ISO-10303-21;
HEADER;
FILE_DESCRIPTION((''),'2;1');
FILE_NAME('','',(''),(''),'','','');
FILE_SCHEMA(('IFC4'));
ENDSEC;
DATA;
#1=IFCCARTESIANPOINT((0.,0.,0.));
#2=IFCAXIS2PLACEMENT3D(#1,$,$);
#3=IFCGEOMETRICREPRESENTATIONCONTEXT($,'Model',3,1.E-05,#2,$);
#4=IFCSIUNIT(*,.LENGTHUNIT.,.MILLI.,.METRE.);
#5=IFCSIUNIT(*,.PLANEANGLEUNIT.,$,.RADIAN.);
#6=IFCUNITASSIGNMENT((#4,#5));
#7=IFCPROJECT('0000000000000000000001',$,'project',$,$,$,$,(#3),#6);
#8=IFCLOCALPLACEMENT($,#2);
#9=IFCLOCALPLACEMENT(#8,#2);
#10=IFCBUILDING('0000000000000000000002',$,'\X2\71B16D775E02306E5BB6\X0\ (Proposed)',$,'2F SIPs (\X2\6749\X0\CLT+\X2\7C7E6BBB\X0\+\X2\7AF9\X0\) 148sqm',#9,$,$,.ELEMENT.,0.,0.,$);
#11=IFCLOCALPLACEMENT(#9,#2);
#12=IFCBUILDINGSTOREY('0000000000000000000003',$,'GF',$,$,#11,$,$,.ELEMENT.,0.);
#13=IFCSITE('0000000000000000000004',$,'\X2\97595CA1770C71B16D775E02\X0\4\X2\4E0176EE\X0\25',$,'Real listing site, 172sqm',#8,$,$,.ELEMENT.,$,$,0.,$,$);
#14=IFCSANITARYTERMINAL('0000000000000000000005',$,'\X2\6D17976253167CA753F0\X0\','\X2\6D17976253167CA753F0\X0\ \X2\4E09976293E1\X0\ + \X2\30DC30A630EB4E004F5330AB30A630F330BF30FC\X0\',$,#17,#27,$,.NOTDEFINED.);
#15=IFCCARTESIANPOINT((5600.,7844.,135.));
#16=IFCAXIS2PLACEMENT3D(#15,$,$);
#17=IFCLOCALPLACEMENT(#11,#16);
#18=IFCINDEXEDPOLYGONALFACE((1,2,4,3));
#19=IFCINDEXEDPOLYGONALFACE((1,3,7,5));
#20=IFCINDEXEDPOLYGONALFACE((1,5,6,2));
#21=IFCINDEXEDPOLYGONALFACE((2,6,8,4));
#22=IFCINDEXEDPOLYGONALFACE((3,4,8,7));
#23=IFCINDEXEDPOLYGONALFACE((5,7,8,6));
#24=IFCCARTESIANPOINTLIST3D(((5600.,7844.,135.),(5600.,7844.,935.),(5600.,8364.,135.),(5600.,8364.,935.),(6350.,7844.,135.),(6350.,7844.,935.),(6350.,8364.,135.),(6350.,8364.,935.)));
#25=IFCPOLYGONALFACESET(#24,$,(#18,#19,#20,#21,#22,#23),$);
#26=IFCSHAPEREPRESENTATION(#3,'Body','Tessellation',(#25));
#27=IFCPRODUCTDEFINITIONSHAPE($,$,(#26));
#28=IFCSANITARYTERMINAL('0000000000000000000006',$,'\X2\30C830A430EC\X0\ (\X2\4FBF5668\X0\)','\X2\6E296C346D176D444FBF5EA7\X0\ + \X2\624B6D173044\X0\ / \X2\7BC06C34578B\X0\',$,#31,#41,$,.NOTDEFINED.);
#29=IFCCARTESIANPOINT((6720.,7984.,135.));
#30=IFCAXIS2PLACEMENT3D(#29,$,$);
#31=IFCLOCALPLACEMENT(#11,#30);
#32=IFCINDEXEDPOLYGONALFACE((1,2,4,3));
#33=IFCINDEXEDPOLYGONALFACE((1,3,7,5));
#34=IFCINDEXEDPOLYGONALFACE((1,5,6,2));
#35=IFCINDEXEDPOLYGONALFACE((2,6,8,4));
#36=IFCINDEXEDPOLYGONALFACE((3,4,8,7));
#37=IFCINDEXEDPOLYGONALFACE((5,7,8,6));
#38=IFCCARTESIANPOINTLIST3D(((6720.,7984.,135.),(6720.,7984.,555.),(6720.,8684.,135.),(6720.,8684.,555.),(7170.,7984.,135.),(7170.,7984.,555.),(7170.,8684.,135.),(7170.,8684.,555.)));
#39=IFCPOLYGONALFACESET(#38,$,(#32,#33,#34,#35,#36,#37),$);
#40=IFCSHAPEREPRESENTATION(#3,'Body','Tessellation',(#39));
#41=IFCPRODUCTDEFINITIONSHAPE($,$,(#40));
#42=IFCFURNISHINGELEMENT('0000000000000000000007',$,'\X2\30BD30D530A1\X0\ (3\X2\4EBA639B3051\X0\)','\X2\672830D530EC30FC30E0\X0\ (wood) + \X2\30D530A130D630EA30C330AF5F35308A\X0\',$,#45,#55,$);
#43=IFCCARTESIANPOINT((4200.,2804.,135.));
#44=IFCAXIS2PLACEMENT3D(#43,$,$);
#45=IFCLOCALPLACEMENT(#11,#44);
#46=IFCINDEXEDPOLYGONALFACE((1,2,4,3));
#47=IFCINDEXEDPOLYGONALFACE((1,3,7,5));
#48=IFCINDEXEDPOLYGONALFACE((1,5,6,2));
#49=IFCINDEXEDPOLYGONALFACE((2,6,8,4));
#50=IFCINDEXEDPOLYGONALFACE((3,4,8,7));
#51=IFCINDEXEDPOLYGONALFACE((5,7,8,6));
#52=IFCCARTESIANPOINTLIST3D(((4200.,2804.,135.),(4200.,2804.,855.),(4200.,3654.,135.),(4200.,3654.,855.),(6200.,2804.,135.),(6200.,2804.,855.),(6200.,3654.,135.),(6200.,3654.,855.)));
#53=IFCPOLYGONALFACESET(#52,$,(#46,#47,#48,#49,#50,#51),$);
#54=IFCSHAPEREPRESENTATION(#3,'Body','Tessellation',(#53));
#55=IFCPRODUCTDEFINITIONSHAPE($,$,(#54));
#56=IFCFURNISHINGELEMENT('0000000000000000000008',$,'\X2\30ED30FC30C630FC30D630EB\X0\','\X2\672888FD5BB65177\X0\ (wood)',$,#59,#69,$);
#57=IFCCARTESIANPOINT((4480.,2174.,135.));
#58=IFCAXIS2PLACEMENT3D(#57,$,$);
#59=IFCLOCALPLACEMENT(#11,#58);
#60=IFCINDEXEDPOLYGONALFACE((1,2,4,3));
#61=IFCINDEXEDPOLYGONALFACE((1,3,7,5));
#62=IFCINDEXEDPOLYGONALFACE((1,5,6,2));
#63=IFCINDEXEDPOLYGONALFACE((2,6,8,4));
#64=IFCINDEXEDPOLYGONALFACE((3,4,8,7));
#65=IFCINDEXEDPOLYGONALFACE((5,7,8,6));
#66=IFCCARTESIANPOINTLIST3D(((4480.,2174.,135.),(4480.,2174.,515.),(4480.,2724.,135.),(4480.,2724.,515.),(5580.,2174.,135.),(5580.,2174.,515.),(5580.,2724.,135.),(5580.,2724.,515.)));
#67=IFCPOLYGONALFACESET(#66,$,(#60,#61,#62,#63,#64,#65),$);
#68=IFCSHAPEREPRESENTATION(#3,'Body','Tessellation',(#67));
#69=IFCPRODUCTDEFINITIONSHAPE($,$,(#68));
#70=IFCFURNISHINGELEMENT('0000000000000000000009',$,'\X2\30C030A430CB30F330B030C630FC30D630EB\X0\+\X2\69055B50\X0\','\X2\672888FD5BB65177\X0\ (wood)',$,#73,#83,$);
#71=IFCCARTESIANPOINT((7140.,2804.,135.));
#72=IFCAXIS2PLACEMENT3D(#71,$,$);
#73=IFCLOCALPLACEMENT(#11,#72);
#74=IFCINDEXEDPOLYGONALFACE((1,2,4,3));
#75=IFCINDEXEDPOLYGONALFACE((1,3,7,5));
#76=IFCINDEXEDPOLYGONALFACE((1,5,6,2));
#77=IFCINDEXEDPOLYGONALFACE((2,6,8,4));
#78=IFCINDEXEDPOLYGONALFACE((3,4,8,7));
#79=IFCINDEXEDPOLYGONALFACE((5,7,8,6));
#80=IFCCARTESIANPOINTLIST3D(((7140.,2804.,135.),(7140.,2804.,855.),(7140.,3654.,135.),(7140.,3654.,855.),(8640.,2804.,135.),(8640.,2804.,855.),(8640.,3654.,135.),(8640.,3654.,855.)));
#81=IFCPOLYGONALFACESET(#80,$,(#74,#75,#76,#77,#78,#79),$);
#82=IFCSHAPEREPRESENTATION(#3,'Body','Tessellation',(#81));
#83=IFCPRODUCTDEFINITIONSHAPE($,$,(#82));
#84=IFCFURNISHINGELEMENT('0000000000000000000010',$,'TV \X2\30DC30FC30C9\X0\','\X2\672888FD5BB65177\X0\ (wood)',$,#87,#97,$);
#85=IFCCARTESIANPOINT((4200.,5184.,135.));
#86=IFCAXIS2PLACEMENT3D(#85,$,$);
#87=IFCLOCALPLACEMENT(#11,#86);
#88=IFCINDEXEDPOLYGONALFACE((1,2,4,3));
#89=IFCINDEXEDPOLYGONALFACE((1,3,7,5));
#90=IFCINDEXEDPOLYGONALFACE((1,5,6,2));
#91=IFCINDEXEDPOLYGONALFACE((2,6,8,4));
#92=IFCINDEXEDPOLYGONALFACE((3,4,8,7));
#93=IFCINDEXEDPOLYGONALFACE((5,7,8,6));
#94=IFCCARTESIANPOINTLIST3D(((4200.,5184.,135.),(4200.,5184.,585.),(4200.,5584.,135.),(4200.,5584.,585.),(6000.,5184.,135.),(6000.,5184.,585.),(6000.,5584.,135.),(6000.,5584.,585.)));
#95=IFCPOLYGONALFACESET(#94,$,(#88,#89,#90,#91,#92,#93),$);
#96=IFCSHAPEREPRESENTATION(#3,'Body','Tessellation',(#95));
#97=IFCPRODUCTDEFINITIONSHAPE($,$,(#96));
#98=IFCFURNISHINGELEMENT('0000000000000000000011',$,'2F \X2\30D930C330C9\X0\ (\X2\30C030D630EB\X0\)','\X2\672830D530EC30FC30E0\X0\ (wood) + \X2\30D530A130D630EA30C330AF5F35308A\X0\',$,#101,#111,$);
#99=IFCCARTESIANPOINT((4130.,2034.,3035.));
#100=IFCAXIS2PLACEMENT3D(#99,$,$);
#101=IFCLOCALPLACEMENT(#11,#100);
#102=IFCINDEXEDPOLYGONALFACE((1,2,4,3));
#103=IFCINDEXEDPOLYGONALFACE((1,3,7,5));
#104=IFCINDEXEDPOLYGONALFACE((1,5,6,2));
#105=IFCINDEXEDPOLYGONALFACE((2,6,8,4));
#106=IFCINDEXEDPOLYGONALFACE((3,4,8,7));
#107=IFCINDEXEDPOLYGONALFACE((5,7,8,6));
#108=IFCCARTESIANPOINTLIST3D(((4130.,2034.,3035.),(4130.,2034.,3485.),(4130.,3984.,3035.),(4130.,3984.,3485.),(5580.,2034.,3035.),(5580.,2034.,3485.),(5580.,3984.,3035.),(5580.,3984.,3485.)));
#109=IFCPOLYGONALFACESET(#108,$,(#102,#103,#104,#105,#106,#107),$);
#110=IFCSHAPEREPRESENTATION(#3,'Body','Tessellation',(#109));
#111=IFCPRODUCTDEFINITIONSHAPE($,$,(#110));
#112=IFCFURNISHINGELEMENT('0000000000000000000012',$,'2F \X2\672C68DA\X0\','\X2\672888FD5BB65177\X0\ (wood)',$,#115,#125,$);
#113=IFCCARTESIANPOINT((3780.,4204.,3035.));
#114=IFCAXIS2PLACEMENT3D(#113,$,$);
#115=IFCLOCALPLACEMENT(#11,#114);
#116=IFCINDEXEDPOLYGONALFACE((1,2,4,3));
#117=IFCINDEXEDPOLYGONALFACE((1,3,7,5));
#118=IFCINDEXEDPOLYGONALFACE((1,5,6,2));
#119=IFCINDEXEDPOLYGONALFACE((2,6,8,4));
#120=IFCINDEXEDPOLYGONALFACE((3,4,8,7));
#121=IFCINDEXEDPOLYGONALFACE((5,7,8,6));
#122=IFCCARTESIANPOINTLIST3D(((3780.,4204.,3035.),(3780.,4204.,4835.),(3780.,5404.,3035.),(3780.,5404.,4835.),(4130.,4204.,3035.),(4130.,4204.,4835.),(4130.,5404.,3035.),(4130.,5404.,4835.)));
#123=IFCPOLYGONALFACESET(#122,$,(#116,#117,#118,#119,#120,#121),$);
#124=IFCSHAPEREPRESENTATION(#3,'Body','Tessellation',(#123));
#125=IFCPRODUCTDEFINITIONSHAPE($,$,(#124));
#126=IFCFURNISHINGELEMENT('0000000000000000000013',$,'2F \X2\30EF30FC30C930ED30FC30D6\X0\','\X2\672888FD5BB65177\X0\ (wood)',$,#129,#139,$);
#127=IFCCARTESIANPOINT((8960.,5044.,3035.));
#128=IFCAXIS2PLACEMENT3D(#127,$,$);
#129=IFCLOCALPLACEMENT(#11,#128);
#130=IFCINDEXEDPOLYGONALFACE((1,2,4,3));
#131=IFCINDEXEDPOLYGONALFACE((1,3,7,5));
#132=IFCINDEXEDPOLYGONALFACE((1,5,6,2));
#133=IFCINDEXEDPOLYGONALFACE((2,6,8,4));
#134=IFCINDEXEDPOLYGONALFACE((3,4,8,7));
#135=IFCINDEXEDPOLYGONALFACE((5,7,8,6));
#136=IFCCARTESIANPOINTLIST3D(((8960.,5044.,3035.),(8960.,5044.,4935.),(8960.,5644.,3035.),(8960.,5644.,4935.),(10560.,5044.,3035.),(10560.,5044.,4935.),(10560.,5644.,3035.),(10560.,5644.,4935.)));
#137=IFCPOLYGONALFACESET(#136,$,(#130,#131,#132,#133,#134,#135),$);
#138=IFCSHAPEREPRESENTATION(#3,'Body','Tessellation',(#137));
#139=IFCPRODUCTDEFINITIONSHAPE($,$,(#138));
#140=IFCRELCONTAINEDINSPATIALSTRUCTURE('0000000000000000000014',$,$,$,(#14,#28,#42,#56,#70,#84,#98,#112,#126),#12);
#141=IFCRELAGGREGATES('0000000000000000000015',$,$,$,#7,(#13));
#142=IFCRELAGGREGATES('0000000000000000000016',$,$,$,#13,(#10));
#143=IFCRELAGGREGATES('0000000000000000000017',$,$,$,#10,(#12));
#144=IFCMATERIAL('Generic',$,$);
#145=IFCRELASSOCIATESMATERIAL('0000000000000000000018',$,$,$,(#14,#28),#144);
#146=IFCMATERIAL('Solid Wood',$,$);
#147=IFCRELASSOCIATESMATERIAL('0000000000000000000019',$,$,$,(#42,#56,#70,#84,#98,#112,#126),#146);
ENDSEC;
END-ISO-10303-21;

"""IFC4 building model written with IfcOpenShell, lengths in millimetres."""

from ifc_helpers import new_model, si_unit, frame, frame_2d, origin, place, context, project, spatial, rectangle, extrude, material, element, save


model = new_model("IFC4")

# Units and contexts
model_context = context("Model", 3, precision=1e-05, world=origin())
ifc_project = project(units=[si_unit("LENGTHUNIT", "METRE", prefix="MILLI"), si_unit("PLANEANGLEUNIT", "RADIAN")], contexts=[model_context])

# Site, building, storey
site_placement = place(None, origin())
site = spatial("IfcSite", under=ifc_project, at=site_placement, Name="静岡県熱海市4丁目25", ObjectType="Real listing site, 172sqm", CompositionType="ELEMENT", RefElevation=0.0)
building_placement = place(site_placement, origin())
building = spatial("IfcBuilding", under=site, at=building_placement, Name="熱海市の家 (Proposed)", ObjectType="2F SIPs (杉CLT+籾殻+竹) 148sqm", CompositionType="ELEMENT", ElevationOfRefHeight=0.0, ElevationOfTerrain=0.0)
storey_placement = place(building_placement, origin())
storey = spatial("IfcBuildingStorey", under=building, at=storey_placement, Name="GF", CompositionType="ELEMENT", Elevation=0.0)

# Shared definitions
ifc_material_1 = material(Name="Solid Wood")

# Shared definitions
ifc_material_2 = material(Name="Generic")

# Sanitary terminals
sanitary_terminal_1_placement = place(storey_placement, frame((5600.0, 7844.0, 135.0)))
element("IfcSanitaryTerminal", 1, at=sanitary_terminal_1_placement, inside=storey, material=ifc_material_2, Name="洗面化粧台", Description="洗面化粧台 三面鏡 + ボウル一体カウンター", PredefinedType="NOTDEFINED", context=model_context, shape_type="SweptSolid", body=[
    extrude(rectangle(XDim=750.0, YDim=520.0, at=frame_2d((375.0, 260.0))), frame((5600.0, 7844.0, 135.0)), (0.0, 0.0, 1.0), 800.0),
])
sanitary_terminal_2_placement = place(storey_placement, frame((6720.0, 7984.0, 135.0)))
element("IfcSanitaryTerminal", 2, at=sanitary_terminal_2_placement, inside=storey, material=ifc_material_2, Name="トイレ (便器)", Description="温水洗浄便座 + 手洗い / 節水型", PredefinedType="NOTDEFINED", context=model_context, shape_type="SweptSolid", body=[
    extrude(rectangle(XDim=450.0, YDim=700.0, at=frame_2d((225.0, 350.0))), frame((6720.0, 7984.0, 135.0)), (0.0, 0.0, 1.0), 420.0),
])

# Furnishing elements
furnishing_1_placement = place(storey_placement, frame((4200.0, 2804.0, 135.0)))
element("IfcFurnishingElement", 3, at=furnishing_1_placement, inside=storey, material=ifc_material_1, Name="ソファ (3人掛け)", Description="木フレーム (wood) + ファブリック張り", context=model_context, shape_type="SweptSolid", body=[
    extrude(rectangle(XDim=2000.0, YDim=850.0, at=frame_2d((1000.0, 425.0))), frame((4200.0, 2804.0, 135.0)), (0.0, 0.0, 1.0), 720.0),
])
furnishing_2_placement = place(storey_placement, frame((4480.0, 2174.0, 135.0)))
element("IfcFurnishingElement", 4, at=furnishing_2_placement, inside=storey, material=ifc_material_1, Name="ローテーブル", Description="木製家具 (wood)", context=model_context, shape_type="SweptSolid", body=[
    extrude(rectangle(XDim=1100.0, YDim=550.0, at=frame_2d((550.0, 275.0))), frame((4480.0, 2174.0, 135.0)), (0.0, 0.0, 1.0), 380.0),
])
furnishing_3_placement = place(storey_placement, frame((7140.0, 2804.0, 135.0)))
element("IfcFurnishingElement", 5, at=furnishing_3_placement, inside=storey, material=ifc_material_1, Name="ダイニングテーブル+椅子", Description="木製家具 (wood)", context=model_context, shape_type="SweptSolid", body=[
    extrude(rectangle(XDim=1500.0, YDim=850.0, at=frame_2d((750.0, 425.0))), frame((7140.0, 2804.0, 135.0)), (0.0, 0.0, 1.0), 720.0),
])
furnishing_4_placement = place(storey_placement, frame((4200.0, 5184.0, 135.0)))
element("IfcFurnishingElement", 6, at=furnishing_4_placement, inside=storey, material=ifc_material_1, Name="TV ボード", Description="木製家具 (wood)", context=model_context, shape_type="SweptSolid", body=[
    extrude(rectangle(XDim=1800.0, YDim=400.0, at=frame_2d((900.0, 200.0))), frame((4200.0, 5184.0, 135.0)), (0.0, 0.0, 1.0), 450.0),
])
furnishing_5_placement = place(storey_placement, frame((4130.0, 2034.0, 3035.0)))
element("IfcFurnishingElement", 7, at=furnishing_5_placement, inside=storey, material=ifc_material_1, Name="2F ベッド (ダブル)", Description="木フレーム (wood) + ファブリック張り", context=model_context, shape_type="SweptSolid", body=[
    extrude(rectangle(XDim=1450.0, YDim=1950.0, at=frame_2d((725.0, 975.0))), frame((4130.0, 2034.0, 3035.0)), (0.0, 0.0, 1.0), 450.0),
])
furnishing_6_placement = place(storey_placement, frame((3780.0, 4204.0, 3035.0)))
element("IfcFurnishingElement", 8, at=furnishing_6_placement, inside=storey, material=ifc_material_1, Name="2F 本棚", Description="木製家具 (wood)", context=model_context, shape_type="SweptSolid", body=[
    extrude(rectangle(XDim=350.0, YDim=1200.0, at=frame_2d((175.0, 600.0))), frame((3780.0, 4204.0, 3035.0)), (0.0, 0.0, 1.0), 1800.0),
])
furnishing_7_placement = place(storey_placement, frame((8960.0, 5044.0, 3035.0)))
element("IfcFurnishingElement", 9, at=furnishing_7_placement, inside=storey, material=ifc_material_1, Name="2F ワードローブ", Description="木製家具 (wood)", context=model_context, shape_type="SweptSolid", body=[
    extrude(rectangle(XDim=1600.0, YDim=600.0, at=frame_2d((800.0, 300.0))), frame((8960.0, 5044.0, 3035.0)), (0.0, 0.0, 1.0), 1900.0),
])

save(model, "model.ifc")
